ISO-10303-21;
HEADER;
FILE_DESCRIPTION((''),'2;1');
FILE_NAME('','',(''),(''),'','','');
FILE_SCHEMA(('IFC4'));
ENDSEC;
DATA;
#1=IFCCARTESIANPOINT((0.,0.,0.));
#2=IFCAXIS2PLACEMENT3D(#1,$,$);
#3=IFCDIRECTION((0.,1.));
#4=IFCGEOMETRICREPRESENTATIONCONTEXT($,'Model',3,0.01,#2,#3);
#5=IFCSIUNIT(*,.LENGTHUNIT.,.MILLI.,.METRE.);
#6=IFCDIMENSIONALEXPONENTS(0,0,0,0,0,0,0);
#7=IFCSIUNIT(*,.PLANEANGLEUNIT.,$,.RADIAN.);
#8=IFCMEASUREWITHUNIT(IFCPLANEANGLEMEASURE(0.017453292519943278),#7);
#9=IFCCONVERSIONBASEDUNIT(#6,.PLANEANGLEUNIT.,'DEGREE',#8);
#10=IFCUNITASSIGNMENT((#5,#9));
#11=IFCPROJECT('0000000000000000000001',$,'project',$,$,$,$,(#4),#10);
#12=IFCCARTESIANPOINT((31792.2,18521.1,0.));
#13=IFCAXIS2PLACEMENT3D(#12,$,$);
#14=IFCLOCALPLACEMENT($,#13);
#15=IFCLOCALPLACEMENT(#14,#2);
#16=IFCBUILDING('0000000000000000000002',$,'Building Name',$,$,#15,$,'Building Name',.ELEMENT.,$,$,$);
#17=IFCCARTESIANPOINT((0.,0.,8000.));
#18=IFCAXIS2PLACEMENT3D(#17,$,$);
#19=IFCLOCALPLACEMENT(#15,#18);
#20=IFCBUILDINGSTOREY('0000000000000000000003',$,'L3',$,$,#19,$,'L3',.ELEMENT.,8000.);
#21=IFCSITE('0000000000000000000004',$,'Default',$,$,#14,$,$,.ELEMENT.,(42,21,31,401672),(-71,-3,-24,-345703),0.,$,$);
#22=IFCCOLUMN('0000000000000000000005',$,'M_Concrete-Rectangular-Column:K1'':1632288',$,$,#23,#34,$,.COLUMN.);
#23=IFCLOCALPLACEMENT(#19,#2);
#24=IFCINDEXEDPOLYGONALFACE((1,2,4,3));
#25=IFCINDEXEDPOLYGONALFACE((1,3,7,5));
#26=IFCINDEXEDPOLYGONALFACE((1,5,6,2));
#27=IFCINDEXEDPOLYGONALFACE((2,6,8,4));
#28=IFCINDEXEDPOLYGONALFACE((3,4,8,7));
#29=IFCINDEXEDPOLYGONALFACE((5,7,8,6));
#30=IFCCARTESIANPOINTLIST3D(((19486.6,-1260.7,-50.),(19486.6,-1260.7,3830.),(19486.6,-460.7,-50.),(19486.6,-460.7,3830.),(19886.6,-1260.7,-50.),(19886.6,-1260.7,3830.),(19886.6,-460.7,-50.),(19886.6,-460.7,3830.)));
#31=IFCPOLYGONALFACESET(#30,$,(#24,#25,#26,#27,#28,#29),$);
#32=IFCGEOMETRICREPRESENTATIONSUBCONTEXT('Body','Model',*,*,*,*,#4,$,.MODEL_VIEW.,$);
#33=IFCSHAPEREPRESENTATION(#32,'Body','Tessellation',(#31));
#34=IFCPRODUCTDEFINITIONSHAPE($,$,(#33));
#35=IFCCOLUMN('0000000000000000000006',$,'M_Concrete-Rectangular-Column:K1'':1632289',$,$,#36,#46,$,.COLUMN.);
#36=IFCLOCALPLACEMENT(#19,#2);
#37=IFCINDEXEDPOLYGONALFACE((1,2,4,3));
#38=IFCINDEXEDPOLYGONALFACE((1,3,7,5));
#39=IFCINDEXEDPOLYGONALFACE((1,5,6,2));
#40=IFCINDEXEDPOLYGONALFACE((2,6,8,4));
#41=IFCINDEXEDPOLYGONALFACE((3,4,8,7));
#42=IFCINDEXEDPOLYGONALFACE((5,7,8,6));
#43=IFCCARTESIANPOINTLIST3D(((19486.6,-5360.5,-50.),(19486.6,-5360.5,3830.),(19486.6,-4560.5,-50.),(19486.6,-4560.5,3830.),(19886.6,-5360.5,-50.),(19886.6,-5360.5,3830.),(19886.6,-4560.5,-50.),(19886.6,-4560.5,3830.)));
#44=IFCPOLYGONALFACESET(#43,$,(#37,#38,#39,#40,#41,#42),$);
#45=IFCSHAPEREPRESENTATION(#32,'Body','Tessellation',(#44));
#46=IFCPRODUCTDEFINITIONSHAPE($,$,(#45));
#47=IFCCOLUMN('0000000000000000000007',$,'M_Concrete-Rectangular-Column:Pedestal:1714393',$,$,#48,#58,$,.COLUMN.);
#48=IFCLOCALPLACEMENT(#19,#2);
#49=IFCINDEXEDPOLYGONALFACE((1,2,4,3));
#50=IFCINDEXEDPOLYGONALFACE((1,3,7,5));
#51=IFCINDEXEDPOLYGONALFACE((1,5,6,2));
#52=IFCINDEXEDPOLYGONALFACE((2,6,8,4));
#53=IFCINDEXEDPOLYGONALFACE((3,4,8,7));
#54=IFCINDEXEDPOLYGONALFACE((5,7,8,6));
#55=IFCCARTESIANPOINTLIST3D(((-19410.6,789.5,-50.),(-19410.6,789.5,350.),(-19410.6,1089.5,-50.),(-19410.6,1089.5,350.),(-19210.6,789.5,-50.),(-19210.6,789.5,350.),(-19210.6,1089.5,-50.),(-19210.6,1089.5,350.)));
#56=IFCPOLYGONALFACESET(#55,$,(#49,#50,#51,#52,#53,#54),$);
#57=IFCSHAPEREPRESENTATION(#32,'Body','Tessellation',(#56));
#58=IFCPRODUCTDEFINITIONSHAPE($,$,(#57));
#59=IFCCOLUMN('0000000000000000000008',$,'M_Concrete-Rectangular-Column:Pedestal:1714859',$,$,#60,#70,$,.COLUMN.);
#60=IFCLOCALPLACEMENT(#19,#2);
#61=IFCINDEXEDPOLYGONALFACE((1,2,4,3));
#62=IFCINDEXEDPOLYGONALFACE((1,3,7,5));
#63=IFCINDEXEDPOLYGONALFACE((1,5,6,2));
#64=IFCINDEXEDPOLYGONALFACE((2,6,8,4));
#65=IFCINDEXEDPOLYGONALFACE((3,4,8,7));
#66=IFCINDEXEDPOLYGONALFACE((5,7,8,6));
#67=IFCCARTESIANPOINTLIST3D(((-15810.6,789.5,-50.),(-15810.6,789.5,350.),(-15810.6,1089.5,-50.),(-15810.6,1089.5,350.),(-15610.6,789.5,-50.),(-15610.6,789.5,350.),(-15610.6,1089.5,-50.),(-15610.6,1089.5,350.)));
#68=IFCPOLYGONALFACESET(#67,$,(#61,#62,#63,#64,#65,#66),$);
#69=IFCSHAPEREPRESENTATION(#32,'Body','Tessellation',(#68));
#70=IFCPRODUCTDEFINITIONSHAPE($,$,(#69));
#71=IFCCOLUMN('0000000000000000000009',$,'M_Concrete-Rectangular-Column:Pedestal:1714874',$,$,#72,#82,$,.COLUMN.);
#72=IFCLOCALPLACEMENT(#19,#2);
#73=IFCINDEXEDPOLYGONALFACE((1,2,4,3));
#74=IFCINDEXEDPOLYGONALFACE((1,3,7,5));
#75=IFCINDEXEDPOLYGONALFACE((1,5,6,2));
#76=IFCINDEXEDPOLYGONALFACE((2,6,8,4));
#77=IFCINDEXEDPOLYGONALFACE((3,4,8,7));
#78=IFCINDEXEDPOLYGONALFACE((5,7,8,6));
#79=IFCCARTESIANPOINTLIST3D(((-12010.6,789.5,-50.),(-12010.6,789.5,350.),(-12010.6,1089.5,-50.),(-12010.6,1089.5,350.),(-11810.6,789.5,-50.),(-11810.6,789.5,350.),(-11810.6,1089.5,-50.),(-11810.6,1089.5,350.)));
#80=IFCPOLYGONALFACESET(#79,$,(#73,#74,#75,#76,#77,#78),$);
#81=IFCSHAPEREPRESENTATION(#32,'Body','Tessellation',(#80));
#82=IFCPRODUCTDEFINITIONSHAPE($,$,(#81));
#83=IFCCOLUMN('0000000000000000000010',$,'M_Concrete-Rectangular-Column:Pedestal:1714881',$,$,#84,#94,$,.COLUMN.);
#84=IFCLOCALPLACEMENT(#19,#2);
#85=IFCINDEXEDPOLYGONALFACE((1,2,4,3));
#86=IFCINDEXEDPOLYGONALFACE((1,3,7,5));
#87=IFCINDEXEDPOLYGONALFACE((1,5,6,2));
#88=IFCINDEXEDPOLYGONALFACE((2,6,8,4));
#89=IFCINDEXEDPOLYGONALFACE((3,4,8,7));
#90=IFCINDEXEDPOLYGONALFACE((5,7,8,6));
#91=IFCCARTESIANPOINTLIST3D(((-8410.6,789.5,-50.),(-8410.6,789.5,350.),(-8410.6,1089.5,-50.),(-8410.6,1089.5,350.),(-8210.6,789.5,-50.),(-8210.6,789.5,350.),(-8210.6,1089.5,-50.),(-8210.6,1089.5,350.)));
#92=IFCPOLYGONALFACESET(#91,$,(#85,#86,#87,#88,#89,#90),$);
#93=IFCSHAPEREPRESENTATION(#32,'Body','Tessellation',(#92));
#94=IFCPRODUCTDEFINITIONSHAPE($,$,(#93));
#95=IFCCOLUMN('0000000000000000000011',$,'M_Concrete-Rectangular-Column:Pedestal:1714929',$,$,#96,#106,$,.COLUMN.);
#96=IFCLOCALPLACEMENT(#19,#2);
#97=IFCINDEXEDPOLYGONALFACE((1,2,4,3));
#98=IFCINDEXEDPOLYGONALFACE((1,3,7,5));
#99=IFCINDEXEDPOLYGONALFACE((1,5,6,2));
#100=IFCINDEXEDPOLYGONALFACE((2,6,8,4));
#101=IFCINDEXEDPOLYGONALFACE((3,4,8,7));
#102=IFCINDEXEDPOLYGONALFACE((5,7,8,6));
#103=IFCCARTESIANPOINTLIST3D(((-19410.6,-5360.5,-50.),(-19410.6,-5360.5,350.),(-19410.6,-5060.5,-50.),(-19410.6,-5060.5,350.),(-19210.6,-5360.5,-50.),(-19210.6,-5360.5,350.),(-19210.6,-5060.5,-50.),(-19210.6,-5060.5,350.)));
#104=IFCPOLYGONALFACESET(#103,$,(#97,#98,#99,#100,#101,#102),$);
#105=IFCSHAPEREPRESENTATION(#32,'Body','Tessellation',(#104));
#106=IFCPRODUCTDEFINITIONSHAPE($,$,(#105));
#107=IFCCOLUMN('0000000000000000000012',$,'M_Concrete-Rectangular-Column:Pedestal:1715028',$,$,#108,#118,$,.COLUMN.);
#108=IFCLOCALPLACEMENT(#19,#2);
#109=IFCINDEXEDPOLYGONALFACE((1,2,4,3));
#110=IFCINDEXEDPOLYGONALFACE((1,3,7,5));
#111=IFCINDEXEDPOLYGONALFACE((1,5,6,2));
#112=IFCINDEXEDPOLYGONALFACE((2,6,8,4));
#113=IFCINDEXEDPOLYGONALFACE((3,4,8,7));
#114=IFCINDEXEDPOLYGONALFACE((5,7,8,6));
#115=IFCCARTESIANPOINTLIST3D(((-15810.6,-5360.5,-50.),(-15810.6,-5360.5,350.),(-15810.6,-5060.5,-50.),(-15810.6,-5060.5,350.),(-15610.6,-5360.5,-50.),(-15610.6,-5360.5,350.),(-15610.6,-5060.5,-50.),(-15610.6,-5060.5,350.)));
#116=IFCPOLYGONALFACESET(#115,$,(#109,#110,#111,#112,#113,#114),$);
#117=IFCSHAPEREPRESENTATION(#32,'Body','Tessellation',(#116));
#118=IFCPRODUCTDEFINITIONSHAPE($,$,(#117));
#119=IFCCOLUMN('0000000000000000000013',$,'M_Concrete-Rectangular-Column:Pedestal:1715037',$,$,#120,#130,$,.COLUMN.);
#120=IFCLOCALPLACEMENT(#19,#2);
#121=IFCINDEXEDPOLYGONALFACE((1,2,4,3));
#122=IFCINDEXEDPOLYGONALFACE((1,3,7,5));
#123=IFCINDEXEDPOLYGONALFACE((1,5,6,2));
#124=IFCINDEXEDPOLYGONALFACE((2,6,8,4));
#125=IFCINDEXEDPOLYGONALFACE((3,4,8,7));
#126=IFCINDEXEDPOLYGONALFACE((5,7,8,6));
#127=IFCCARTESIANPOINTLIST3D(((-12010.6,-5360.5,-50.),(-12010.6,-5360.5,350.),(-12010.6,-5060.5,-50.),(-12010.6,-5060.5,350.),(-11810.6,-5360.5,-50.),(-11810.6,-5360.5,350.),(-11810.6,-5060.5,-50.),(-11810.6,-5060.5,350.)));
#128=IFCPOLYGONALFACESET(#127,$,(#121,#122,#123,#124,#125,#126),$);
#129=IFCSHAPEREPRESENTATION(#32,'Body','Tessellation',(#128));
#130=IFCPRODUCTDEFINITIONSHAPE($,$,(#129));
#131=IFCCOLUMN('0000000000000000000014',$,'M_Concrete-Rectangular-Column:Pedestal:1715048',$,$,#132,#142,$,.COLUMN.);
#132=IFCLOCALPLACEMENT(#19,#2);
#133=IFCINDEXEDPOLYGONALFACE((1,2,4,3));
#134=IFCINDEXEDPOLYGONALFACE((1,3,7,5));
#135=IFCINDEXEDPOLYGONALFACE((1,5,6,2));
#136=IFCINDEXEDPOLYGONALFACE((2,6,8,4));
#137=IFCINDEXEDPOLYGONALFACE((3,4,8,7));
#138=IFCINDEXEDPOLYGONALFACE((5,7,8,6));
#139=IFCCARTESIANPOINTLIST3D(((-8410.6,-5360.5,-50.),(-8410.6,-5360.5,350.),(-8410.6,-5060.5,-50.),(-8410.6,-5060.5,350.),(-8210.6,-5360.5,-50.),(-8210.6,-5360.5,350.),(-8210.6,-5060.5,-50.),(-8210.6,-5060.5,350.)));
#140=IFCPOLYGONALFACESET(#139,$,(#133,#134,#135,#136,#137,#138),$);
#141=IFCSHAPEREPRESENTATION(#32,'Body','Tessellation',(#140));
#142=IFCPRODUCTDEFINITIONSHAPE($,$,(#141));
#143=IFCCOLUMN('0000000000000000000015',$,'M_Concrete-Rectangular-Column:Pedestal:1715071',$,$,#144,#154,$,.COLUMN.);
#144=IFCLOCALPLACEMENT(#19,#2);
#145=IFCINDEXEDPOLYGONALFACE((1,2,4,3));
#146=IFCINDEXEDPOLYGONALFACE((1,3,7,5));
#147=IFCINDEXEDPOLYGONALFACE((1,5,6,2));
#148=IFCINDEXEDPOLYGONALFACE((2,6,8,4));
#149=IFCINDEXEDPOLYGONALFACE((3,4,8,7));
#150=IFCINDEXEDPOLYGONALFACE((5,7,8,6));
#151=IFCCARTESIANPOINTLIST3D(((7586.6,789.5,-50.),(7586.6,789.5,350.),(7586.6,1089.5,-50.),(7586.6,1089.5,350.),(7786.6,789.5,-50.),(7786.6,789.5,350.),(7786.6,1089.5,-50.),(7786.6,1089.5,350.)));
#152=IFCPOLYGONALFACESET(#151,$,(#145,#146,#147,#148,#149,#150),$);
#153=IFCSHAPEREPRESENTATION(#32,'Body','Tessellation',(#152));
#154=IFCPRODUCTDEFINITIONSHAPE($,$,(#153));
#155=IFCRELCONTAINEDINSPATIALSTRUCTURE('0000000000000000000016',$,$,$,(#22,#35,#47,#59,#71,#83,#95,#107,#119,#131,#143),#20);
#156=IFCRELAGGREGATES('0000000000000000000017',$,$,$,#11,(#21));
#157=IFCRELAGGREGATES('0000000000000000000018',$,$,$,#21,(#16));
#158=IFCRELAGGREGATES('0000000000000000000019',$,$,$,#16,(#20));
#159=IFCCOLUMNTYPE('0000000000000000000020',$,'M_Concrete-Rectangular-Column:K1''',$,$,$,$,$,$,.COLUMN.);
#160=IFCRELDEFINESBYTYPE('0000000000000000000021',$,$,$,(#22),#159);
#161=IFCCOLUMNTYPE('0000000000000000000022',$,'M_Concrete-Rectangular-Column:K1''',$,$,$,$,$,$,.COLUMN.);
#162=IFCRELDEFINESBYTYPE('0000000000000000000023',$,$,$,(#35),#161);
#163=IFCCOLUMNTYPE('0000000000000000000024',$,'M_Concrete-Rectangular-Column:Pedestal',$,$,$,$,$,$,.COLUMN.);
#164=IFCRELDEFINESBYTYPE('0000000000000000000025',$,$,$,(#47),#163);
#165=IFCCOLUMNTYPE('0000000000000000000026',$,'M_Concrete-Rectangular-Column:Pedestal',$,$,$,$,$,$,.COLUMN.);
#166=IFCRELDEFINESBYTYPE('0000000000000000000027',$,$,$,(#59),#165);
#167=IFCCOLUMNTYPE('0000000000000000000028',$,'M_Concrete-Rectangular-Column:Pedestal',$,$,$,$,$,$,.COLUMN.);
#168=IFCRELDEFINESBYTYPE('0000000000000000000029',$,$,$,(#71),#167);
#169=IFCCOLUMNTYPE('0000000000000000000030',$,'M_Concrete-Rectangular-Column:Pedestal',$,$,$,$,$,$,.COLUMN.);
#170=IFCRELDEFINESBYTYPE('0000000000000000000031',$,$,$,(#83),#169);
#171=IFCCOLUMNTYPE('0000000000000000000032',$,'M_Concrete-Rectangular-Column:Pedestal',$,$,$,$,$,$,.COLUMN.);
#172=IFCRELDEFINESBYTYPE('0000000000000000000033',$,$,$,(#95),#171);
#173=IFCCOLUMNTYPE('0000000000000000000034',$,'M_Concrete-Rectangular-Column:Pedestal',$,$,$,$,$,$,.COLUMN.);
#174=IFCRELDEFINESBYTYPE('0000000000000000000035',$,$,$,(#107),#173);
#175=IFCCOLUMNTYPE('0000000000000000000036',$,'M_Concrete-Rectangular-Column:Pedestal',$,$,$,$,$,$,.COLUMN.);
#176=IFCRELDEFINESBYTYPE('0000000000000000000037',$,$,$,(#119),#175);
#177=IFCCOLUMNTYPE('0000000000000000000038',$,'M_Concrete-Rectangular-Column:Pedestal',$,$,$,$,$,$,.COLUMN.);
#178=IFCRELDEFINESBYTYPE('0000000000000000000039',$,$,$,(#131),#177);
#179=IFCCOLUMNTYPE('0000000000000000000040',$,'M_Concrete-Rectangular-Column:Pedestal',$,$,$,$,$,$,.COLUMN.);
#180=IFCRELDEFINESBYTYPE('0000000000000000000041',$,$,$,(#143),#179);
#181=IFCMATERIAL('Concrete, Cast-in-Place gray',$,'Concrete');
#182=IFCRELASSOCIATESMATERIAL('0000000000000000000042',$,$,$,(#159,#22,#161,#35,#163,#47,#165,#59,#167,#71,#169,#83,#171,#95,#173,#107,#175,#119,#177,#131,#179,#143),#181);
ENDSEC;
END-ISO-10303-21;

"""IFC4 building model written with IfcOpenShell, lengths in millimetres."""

from ifc_helpers import new_model, entity, si_unit, converted_unit, direction, frame, origin, place, context, subcontext, project, spatial, indexed_curve, outline, extrude, source, transform, mapped, material, type_object, type_shapes, element, save


model = new_model("IFC4")

# Units and contexts
model_context = context("Model", 3, precision=0.01, world=origin(), true_north=direction((0.0, 1.0)))
body_context = subcontext(model_context, "Body", "Model", "MODEL_VIEW")
ifc_project = project(units=[si_unit("LENGTHUNIT", "METRE", prefix="MILLI"), converted_unit("PLANEANGLEUNIT", "DEGREE", entity("IfcPlaneAngleMeasure", 0.017453292519943278), si_unit("PLANEANGLEUNIT", "RADIAN"), dimensions=[0, 0, 0, 0, 0, 0, 0])], contexts=[model_context])

# Site, building, storey
site_placement = place(None, frame((31792.2, 18521.1, 0.0)))
site = spatial("IfcSite", under=ifc_project, at=site_placement, Name="Default", CompositionType="ELEMENT", RefLatitude=(42, 21, 31, 401672), RefLongitude=(-71, -3, -24, -345703), RefElevation=0.0)
building_placement = place(site_placement, origin())
building = spatial("IfcBuilding", under=site, at=building_placement, Name="Building Name", LongName="Building Name", CompositionType="ELEMENT")
storey_placement = place(building_placement, frame((0.0, 0.0, 8000.0)))
storey = spatial("IfcBuildingStorey", under=building, at=storey_placement, Name="L3", LongName="L3", CompositionType="ELEMENT", Elevation=8000.0)

# Columns
ifc_material_1 = material(Name="Concrete, Cast-in-Place gray", Category="Concrete")
column_type_1 = type_object("IfcColumnType", Name="M_Concrete-Rectangular-Column:K1'", PredefinedType="COLUMN", material=ifc_material_1)
shared_shape_1 = source(origin(), body_context, "Body", "SweptSolid", [
    extrude(outline(indexed_curve([(-200.0, -400.0), (200.0, -400.0), (200.0, 400.0), (-200.0, 400.0), (-200.0, -400.0)], self_intersect=False)), frame((19686.6, -860.7, 7950.0)), (0.0, 0.0, 1.0), 3880.0),
])
type_shapes(column_type_1, [shared_shape_1])
column_1_placement = place(storey_placement, frame((0.0, 0.0, -8000.0)))
element("IfcColumn", 1, at=column_1_placement, inside=storey, type_object=column_type_1, material=ifc_material_1, Name="M_Concrete-Rectangular-Column:K1':1632288", PredefinedType="COLUMN", context=body_context, shape_type="MappedRepresentation", body=[
    mapped(shared_shape_1, transform((0.0, 0.0, 0.0), scale=1.0)),
])
column_type_2 = type_object("IfcColumnType", Name="M_Concrete-Rectangular-Column:K1'", PredefinedType="COLUMN", material=ifc_material_1)
shared_shape_2 = source(origin(), body_context, "Body", "SweptSolid", [
    extrude(outline(indexed_curve([(-200.0, -400.0), (200.0, -400.0), (200.0, 400.0), (-200.0, 400.0), (-200.0, -400.0)], self_intersect=False)), frame((19686.6, -4960.5, 7950.0)), (0.0, 0.0, 1.0), 3880.0),
])
type_shapes(column_type_2, [shared_shape_2])
column_2_placement = place(storey_placement, frame((0.0, 0.0, -8000.0)))
element("IfcColumn", 2, at=column_2_placement, inside=storey, type_object=column_type_2, material=ifc_material_1, Name="M_Concrete-Rectangular-Column:K1':1632289", PredefinedType="COLUMN", context=body_context, shape_type="MappedRepresentation", body=[
    mapped(shared_shape_2, transform((0.0, 0.0, 0.0), scale=1.0)),
])
column_type_3 = type_object("IfcColumnType", Name="M_Concrete-Rectangular-Column:Pedestal", PredefinedType="COLUMN", material=ifc_material_1)
shared_shape_3 = source(origin(), body_context, "Body", "SweptSolid", [
    extrude(outline(indexed_curve([(-150.0, -100.0), (150.0, -100.0), (150.0, 100.0), (-150.0, 100.0), (-150.0, -100.0)], self_intersect=False)), frame((-19310.6, 939.5, 7950.0), z_axis=(0.0, 0.0, 1.0), x_axis=(0.0, -1.0, 0.0)), (0.0, 0.0, 1.0), 400.0),
])
type_shapes(column_type_3, [shared_shape_3])
column_3_placement = place(storey_placement, frame((0.0, 0.0, -8000.0)))
element("IfcColumn", 3, at=column_3_placement, inside=storey, type_object=column_type_3, material=ifc_material_1, Name="M_Concrete-Rectangular-Column:Pedestal:1714393", PredefinedType="COLUMN", context=body_context, shape_type="MappedRepresentation", body=[
    mapped(shared_shape_3, transform((0.0, 0.0, 0.0), scale=1.0)),
])
column_type_4 = type_object("IfcColumnType", Name="M_Concrete-Rectangular-Column:Pedestal", PredefinedType="COLUMN", material=ifc_material_1)
shared_shape_4 = source(origin(), body_context, "Body", "SweptSolid", [
    extrude(outline(indexed_curve([(-150.0, -100.0), (150.0, -100.0), (150.0, 100.0), (-150.0, 100.0), (-150.0, -100.0)], self_intersect=False)), frame((-15710.6, 939.5, 7950.0), z_axis=(0.0, 0.0, 1.0), x_axis=(0.0, -1.0, 0.0)), (0.0, 0.0, 1.0), 400.0),
])
type_shapes(column_type_4, [shared_shape_4])
column_4_placement = place(storey_placement, frame((0.0, 0.0, -8000.0)))
element("IfcColumn", 4, at=column_4_placement, inside=storey, type_object=column_type_4, material=ifc_material_1, Name="M_Concrete-Rectangular-Column:Pedestal:1714859", PredefinedType="COLUMN", context=body_context, shape_type="MappedRepresentation", body=[
    mapped(shared_shape_4, transform((0.0, 0.0, 0.0), scale=1.0)),
])
column_type_5 = type_object("IfcColumnType", Name="M_Concrete-Rectangular-Column:Pedestal", PredefinedType="COLUMN", material=ifc_material_1)
shared_shape_5 = source(origin(), body_context, "Body", "SweptSolid", [
    extrude(outline(indexed_curve([(-150.0, -100.0), (150.0, -100.0), (150.0, 100.0), (-150.0, 100.0), (-150.0, -100.0)], self_intersect=False)), frame((-11910.6, 939.5, 7950.0), z_axis=(0.0, 0.0, 1.0), x_axis=(0.0, -1.0, 0.0)), (0.0, 0.0, 1.0), 400.0),
])
type_shapes(column_type_5, [shared_shape_5])
column_5_placement = place(storey_placement, frame((0.0, 0.0, -8000.0)))
element("IfcColumn", 5, at=column_5_placement, inside=storey, type_object=column_type_5, material=ifc_material_1, Name="M_Concrete-Rectangular-Column:Pedestal:1714874", PredefinedType="COLUMN", context=body_context, shape_type="MappedRepresentation", body=[
    mapped(shared_shape_5, transform((0.0, 0.0, 0.0), scale=1.0)),
])
column_type_6 = type_object("IfcColumnType", Name="M_Concrete-Rectangular-Column:Pedestal", PredefinedType="COLUMN", material=ifc_material_1)
shared_shape_6 = source(origin(), body_context, "Body", "SweptSolid", [
    extrude(outline(indexed_curve([(-150.0, -100.0), (150.0, -100.0), (150.0, 100.0), (-150.0, 100.0), (-150.0, -100.0)], self_intersect=False)), frame((-8310.6, 939.5, 7950.0), z_axis=(0.0, 0.0, 1.0), x_axis=(0.0, -1.0, 0.0)), (0.0, 0.0, 1.0), 400.0),
])
type_shapes(column_type_6, [shared_shape_6])
column_6_placement = place(storey_placement, frame((0.0, 0.0, -8000.0)))
element("IfcColumn", 6, at=column_6_placement, inside=storey, type_object=column_type_6, material=ifc_material_1, Name="M_Concrete-Rectangular-Column:Pedestal:1714881", PredefinedType="COLUMN", context=body_context, shape_type="MappedRepresentation", body=[
    mapped(shared_shape_6, transform((0.0, 0.0, 0.0), scale=1.0)),
])
column_type_7 = type_object("IfcColumnType", Name="M_Concrete-Rectangular-Column:Pedestal", PredefinedType="COLUMN", material=ifc_material_1)
shared_shape_7 = source(origin(), body_context, "Body", "SweptSolid", [
    extrude(outline(indexed_curve([(-150.0, -100.0), (150.0, -100.0), (150.0, 100.0), (-150.0, 100.0), (-150.0, -100.0)], self_intersect=False)), frame((-19310.6, -5210.5, 7950.0), z_axis=(0.0, 0.0, 1.0), x_axis=(0.0, -1.0, 0.0)), (0.0, 0.0, 1.0), 400.0),
])
type_shapes(column_type_7, [shared_shape_7])
column_7_placement = place(storey_placement, frame((0.0, 0.0, -8000.0)))
element("IfcColumn", 7, at=column_7_placement, inside=storey, type_object=column_type_7, material=ifc_material_1, Name="M_Concrete-Rectangular-Column:Pedestal:1714929", PredefinedType="COLUMN", context=body_context, shape_type="MappedRepresentation", body=[
    mapped(shared_shape_7, transform((0.0, 0.0, 0.0), scale=1.0)),
])
column_type_8 = type_object("IfcColumnType", Name="M_Concrete-Rectangular-Column:Pedestal", PredefinedType="COLUMN", material=ifc_material_1)
shared_shape_8 = source(origin(), body_context, "Body", "SweptSolid", [
    extrude(outline(indexed_curve([(-150.0, -100.0), (150.0, -100.0), (150.0, 100.0), (-150.0, 100.0), (-150.0, -100.0)], self_intersect=False)), frame((-15710.6, -5210.5, 7950.0), z_axis=(0.0, 0.0, 1.0), x_axis=(0.0, -1.0, 0.0)), (0.0, 0.0, 1.0), 400.0),
])
type_shapes(column_type_8, [shared_shape_8])
column_8_placement = place(storey_placement, frame((0.0, 0.0, -8000.0)))
element("IfcColumn", 8, at=column_8_placement, inside=storey, type_object=column_type_8, material=ifc_material_1, Name="M_Concrete-Rectangular-Column:Pedestal:1715028", PredefinedType="COLUMN", context=body_context, shape_type="MappedRepresentation", body=[
    mapped(shared_shape_8, transform((0.0, 0.0, 0.0), scale=1.0)),
])
column_type_9 = type_object("IfcColumnType", Name="M_Concrete-Rectangular-Column:Pedestal", PredefinedType="COLUMN", material=ifc_material_1)
shared_shape_9 = source(origin(), body_context, "Body", "SweptSolid", [
    extrude(outline(indexed_curve([(-150.0, -100.0), (150.0, -100.0), (150.0, 100.0), (-150.0, 100.0), (-150.0, -100.0)], self_intersect=False)), frame((-11910.6, -5210.5, 7950.0), z_axis=(0.0, 0.0, 1.0), x_axis=(0.0, -1.0, 0.0)), (0.0, 0.0, 1.0), 400.0),
])
type_shapes(column_type_9, [shared_shape_9])
column_9_placement = place(storey_placement, frame((0.0, 0.0, -8000.0)))
element("IfcColumn", 9, at=column_9_placement, inside=storey, type_object=column_type_9, material=ifc_material_1, Name="M_Concrete-Rectangular-Column:Pedestal:1715037", PredefinedType="COLUMN", context=body_context, shape_type="MappedRepresentation", body=[
    mapped(shared_shape_9, transform((0.0, 0.0, 0.0), scale=1.0)),
])
column_type_10 = type_object("IfcColumnType", Name="M_Concrete-Rectangular-Column:Pedestal", PredefinedType="COLUMN", material=ifc_material_1)
shared_shape_10 = source(origin(), body_context, "Body", "SweptSolid", [
    extrude(outline(indexed_curve([(-150.0, -100.0), (150.0, -100.0), (150.0, 100.0), (-150.0, 100.0), (-150.0, -100.0)], self_intersect=False)), frame((-8310.6, -5210.5, 7950.0), z_axis=(0.0, 0.0, 1.0), x_axis=(0.0, -1.0, 0.0)), (0.0, 0.0, 1.0), 400.0),
])
type_shapes(column_type_10, [shared_shape_10])
column_10_placement = place(storey_placement, frame((0.0, 0.0, -8000.0)))
element("IfcColumn", 10, at=column_10_placement, inside=storey, type_object=column_type_10, material=ifc_material_1, Name="M_Concrete-Rectangular-Column:Pedestal:1715048", PredefinedType="COLUMN", context=body_context, shape_type="MappedRepresentation", body=[
    mapped(shared_shape_10, transform((0.0, 0.0, 0.0), scale=1.0)),
])
column_type_11 = type_object("IfcColumnType", Name="M_Concrete-Rectangular-Column:Pedestal", PredefinedType="COLUMN", material=ifc_material_1)
shared_shape_11 = source(origin(), body_context, "Body", "SweptSolid", [
    extrude(outline(indexed_curve([(-150.0, -100.0), (150.0, -100.0), (150.0, 100.0), (-150.0, 100.0), (-150.0, -100.0)], self_intersect=False)), frame((7686.6, 939.5, 7950.0), z_axis=(0.0, 0.0, 1.0), x_axis=(0.0, -1.0, 0.0)), (0.0, 0.0, 1.0), 400.0),
])
type_shapes(column_type_11, [shared_shape_11])
column_11_placement = place(storey_placement, frame((0.0, 0.0, -8000.0)))
element("IfcColumn", 11, at=column_11_placement, inside=storey, type_object=column_type_11, material=ifc_material_1, Name="M_Concrete-Rectangular-Column:Pedestal:1715071", PredefinedType="COLUMN", context=body_context, shape_type="MappedRepresentation", body=[
    mapped(shared_shape_11, transform((0.0, 0.0, 0.0), scale=1.0)),
])

save(model, "model.ifc")
